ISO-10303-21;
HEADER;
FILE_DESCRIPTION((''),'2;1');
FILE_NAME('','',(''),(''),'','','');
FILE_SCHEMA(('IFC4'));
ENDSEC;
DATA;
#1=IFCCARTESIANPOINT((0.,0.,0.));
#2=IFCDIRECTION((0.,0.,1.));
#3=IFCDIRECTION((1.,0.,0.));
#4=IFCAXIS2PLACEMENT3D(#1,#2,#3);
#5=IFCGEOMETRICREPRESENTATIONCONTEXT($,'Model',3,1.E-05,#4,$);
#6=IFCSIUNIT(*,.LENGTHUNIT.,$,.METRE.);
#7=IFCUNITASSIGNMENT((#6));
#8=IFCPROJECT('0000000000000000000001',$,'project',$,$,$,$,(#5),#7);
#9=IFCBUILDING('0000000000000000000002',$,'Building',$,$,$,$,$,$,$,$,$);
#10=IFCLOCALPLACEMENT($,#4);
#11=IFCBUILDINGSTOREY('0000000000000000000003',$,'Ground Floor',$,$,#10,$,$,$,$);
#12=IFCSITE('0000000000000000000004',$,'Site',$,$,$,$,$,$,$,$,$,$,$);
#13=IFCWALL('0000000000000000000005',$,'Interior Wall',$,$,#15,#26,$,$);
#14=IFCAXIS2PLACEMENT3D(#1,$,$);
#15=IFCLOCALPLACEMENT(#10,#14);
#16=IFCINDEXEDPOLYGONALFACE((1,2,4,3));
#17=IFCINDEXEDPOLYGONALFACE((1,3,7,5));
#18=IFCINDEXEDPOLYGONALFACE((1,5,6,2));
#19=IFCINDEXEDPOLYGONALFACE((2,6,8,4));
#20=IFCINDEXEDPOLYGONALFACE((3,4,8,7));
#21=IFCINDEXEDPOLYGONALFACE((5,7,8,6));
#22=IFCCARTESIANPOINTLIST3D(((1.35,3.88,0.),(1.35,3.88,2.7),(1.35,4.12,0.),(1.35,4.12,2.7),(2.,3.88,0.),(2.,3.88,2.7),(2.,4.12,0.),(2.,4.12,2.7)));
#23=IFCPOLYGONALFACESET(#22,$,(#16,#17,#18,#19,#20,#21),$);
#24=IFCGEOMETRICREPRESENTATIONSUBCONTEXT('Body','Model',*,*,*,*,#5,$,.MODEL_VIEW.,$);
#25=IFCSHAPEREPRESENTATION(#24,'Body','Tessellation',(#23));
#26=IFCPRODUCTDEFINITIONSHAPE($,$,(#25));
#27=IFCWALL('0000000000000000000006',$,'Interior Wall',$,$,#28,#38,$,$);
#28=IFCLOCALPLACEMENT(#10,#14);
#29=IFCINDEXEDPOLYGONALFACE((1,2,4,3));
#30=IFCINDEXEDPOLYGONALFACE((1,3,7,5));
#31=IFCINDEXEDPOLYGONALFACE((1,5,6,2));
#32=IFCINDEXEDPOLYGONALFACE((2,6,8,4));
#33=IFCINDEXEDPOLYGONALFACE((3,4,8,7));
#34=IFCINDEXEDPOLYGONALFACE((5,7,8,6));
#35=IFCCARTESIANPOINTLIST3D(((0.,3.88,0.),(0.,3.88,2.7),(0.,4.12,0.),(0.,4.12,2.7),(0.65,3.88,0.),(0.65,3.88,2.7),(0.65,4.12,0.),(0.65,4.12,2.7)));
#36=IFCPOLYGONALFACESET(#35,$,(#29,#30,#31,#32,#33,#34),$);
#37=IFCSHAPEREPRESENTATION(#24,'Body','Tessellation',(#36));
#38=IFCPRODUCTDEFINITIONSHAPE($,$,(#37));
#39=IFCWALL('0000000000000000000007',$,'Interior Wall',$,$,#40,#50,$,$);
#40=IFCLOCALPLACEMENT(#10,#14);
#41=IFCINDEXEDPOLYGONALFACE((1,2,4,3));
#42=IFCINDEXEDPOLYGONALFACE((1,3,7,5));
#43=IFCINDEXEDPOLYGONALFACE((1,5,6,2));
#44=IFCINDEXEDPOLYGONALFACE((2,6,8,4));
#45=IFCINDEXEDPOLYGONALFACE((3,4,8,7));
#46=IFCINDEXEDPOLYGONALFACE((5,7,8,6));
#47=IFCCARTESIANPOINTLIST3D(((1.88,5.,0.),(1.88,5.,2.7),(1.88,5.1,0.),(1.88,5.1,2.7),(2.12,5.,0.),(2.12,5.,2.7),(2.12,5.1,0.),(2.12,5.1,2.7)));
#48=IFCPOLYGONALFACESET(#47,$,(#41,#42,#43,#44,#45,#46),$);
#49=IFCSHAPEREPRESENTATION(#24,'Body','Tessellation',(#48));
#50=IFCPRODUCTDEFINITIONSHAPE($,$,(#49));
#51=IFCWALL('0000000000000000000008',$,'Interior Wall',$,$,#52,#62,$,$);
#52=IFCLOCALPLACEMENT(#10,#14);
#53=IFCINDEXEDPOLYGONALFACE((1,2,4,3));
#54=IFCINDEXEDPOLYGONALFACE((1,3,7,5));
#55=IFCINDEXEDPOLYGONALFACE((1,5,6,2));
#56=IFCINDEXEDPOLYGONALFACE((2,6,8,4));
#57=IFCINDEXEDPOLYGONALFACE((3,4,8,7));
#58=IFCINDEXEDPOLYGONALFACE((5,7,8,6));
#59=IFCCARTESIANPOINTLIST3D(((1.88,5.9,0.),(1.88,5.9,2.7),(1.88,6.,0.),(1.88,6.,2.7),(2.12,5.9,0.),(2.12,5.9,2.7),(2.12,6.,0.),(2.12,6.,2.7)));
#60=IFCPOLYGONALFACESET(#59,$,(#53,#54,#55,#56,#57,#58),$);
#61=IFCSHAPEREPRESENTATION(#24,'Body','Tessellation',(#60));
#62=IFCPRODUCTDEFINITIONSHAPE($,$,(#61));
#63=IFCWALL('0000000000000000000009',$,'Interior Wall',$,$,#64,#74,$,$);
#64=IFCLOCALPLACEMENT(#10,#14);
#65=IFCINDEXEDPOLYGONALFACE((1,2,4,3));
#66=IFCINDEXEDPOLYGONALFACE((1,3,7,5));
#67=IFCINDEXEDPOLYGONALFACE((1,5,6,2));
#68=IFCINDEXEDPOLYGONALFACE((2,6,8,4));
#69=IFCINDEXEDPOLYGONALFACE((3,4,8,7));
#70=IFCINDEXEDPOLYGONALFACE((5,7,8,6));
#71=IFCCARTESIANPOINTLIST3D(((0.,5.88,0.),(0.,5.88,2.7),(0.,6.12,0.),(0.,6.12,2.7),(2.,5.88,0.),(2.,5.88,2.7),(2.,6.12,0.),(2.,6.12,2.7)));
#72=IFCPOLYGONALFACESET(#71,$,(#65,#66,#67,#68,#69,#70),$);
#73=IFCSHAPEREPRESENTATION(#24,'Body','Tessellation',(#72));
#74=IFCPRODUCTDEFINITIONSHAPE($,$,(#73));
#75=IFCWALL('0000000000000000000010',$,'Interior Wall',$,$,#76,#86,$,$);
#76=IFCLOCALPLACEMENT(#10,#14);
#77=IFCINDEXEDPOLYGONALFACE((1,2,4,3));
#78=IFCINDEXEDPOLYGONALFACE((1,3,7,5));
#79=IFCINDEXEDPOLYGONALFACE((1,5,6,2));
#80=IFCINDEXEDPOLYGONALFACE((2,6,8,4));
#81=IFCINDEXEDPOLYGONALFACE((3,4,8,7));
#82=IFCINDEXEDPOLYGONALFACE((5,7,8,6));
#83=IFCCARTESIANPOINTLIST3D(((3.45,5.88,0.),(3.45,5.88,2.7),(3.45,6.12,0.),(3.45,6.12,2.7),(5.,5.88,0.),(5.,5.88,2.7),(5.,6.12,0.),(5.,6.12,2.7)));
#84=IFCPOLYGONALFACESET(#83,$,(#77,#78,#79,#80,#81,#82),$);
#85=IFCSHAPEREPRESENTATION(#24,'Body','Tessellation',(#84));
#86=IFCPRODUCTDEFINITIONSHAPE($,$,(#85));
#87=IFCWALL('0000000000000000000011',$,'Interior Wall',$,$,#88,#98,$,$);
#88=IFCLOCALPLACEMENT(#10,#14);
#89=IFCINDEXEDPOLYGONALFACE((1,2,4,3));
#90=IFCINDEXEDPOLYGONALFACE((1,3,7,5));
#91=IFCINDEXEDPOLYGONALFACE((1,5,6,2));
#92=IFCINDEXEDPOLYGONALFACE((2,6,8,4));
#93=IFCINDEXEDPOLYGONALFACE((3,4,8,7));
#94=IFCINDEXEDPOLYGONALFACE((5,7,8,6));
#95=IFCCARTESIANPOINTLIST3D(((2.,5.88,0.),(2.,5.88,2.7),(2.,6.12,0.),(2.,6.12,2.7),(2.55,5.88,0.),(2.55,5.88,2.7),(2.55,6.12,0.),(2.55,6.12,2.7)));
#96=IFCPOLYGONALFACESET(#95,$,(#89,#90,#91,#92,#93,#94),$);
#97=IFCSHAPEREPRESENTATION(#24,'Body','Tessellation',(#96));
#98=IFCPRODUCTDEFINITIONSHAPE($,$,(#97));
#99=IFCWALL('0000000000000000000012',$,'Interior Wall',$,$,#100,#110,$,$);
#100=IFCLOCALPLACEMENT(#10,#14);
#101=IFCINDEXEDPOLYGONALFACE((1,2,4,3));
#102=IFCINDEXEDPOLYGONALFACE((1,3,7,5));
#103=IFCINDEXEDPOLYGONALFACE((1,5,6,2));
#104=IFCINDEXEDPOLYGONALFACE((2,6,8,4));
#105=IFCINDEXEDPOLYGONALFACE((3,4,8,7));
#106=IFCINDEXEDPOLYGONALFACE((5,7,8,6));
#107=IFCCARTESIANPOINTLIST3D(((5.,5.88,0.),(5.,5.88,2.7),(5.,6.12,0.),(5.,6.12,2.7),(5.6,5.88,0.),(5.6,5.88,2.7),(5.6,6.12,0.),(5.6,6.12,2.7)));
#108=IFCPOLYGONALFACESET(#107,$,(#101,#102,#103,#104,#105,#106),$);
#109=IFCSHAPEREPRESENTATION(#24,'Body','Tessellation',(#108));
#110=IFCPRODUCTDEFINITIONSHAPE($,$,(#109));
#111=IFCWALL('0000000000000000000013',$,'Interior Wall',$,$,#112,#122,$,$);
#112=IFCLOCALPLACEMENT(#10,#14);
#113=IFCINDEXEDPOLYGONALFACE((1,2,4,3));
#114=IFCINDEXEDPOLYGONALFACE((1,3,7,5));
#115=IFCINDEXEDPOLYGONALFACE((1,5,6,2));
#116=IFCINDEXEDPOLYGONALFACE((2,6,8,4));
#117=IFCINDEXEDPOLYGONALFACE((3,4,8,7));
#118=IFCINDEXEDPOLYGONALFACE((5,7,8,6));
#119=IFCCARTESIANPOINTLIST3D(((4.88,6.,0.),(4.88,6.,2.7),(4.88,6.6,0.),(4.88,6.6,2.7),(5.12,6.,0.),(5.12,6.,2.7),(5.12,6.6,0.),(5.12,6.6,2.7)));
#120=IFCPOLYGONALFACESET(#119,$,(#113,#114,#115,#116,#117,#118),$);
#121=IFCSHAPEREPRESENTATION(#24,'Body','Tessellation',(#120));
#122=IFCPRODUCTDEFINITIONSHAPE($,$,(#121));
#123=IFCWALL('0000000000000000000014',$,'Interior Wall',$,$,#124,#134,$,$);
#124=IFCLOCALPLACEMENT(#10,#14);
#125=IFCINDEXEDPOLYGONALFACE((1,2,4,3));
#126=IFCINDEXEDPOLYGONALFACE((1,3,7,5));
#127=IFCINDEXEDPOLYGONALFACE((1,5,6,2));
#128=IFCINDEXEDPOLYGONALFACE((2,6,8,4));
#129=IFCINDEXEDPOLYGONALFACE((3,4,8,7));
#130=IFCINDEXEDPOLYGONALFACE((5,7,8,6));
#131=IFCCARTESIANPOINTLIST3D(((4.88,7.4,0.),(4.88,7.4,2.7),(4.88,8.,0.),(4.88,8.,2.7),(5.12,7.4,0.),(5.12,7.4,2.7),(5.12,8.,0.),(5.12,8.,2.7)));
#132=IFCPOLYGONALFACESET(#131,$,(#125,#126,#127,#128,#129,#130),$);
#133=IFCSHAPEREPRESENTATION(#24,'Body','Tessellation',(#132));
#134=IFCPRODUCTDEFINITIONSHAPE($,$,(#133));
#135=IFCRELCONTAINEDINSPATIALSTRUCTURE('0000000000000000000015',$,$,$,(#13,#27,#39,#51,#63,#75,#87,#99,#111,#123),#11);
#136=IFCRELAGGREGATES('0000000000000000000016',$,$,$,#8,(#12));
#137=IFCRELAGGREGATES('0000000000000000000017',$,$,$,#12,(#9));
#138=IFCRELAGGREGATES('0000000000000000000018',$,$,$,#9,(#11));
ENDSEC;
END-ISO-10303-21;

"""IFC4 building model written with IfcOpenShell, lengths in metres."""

from ifc_helpers import new_model, si_unit, frame, origin_with_axes, place, context, subcontext, project, spatial, indexed_curve, outline, extrude, element, save


model = new_model("IFC4")

# Units and contexts
model_context = context("Model", 3, precision=1e-05, world=origin_with_axes())
body_context = subcontext(model_context, "Body", "Model", "MODEL_VIEW")
ifc_project = project(units=[si_unit("LENGTHUNIT", "METRE")], contexts=[model_context])

# Site, building, storey
site = spatial("IfcSite", under=ifc_project, Name="Site")
building = spatial("IfcBuilding", under=site, Name="Building")
storey_placement = place(None, origin_with_axes())
storey = spatial("IfcBuildingStorey", under=building, at=storey_placement, Name="Ground Floor")

# Walls
for number, where, z_axis, x_axis, name in (
    (1, (2.0, 4.0, 0.0), (0.0, 0.0, 1.0), (-1.0, 0.0, 0.0), "Interior Wall"),
    (2, (0.65, 4.0, 0.0), (0.0, 0.0, 1.0), (-1.0, 0.0, 0.0), "Interior Wall"),
):
    element("IfcWall", number, at=place(storey_placement, frame(where, z_axis=z_axis, x_axis=x_axis)), inside=storey, Name=name, context=body_context, shape_type="SweptSolid", body=[
        extrude(outline(indexed_curve([(0.0, 0.0), (0.0, 0.24), (0.65, 0.24), (0.65, 0.0), (0.0, 0.0)], self_intersect=False)), frame((0.0, -0.12, 0.0), z_axis=(0.0, 0.0, 1.0), x_axis=(1.0, 0.0, 0.0)), (0.0, 0.0, 1.0), 2.7),
    ])
for number, where, z_axis, x_axis, name in (
    (3, (2.0, 5.0, 0.0), (0.0, 0.0, 1.0), (0.0, 1.0, 0.0), "Interior Wall"),
    (4, (2.0, 5.9, 0.0), (0.0, 0.0, 1.0), (0.0, 1.0, 0.0), "Interior Wall"),
):
    element("IfcWall", number, at=place(storey_placement, frame(where, z_axis=z_axis, x_axis=x_axis)), inside=storey, Name=name, context=body_context, shape_type="SweptSolid", body=[
        extrude(outline(indexed_curve([(0.0, 0.0), (0.0, 0.24), (0.1, 0.24), (0.1, 0.0), (0.0, 0.0)], self_intersect=False)), frame((0.0, -0.12, 0.0), z_axis=(0.0, 0.0, 1.0), x_axis=(1.0, 0.0, 0.0)), (0.0, 0.0, 1.0), 2.7),
    ])
wall_1_placement = place(storey_placement, frame((2.0, 6.0, 0.0), z_axis=(0.0, 0.0, 1.0), x_axis=(-1.0, 0.0, 0.0)))
element("IfcWall", 5, at=wall_1_placement, inside=storey, Name="Interior Wall", context=body_context, shape_type="SweptSolid", body=[
    extrude(outline(indexed_curve([(0.0, 0.0), (0.0, 0.24), (2.0, 0.24), (2.0, 0.0), (0.0, 0.0)], self_intersect=False)), frame((0.0, -0.12, 0.0), z_axis=(0.0, 0.0, 1.0), x_axis=(1.0, 0.0, 0.0)), (0.0, 0.0, 1.0), 2.7),
])
wall_2_placement = place(storey_placement, frame((5.0, 6.0, 0.0), z_axis=(0.0, 0.0, 1.0), x_axis=(-1.0, 0.0, 0.0)))
element("IfcWall", 6, at=wall_2_placement, inside=storey, Name="Interior Wall", context=body_context, shape_type="SweptSolid", body=[
    extrude(outline(indexed_curve([(0.0, 0.0), (0.0, 0.24), (1.55, 0.24), (1.55, 0.0), (0.0, 0.0)], self_intersect=False)), frame((0.0, -0.12, 0.0), z_axis=(0.0, 0.0, 1.0), x_axis=(1.0, 0.0, 0.0)), (0.0, 0.0, 1.0), 2.7),
])
wall_3_placement = place(storey_placement, frame((2.55, 6.0, 0.0), z_axis=(0.0, 0.0, 1.0), x_axis=(-1.0, 0.0, 0.0)))
element("IfcWall", 7, at=wall_3_placement, inside=storey, Name="Interior Wall", context=body_context, shape_type="SweptSolid", body=[
    extrude(outline(indexed_curve([(0.0, 0.0), (0.0, 0.24), (0.55, 0.24), (0.55, 0.0), (0.0, 0.0)], self_intersect=False)), frame((0.0, -0.12, 0.0), z_axis=(0.0, 0.0, 1.0), x_axis=(1.0, 0.0, 0.0)), (0.0, 0.0, 1.0), 2.7),
])
for number, where, z_axis, x_axis, name in (
    (8, (5.6, 6.0, 0.0), (0.0, 0.0, 1.0), (-1.0, 0.0, 0.0), "Interior Wall"),
    (9, (5.0, 6.0, 0.0), (0.0, 0.0, 1.0), (0.0, 1.0, 0.0), "Interior Wall"),
    (10, (5.0, 7.4, 0.0), (0.0, 0.0, 1.0), (0.0, 1.0, 0.0), "Interior Wall"),
):
    element("IfcWall", number, at=place(storey_placement, frame(where, z_axis=z_axis, x_axis=x_axis)), inside=storey, Name=name, context=body_context, shape_type="SweptSolid", body=[
        extrude(outline(indexed_curve([(0.0, 0.0), (0.0, 0.24), (0.6, 0.24), (0.6, 0.0), (0.0, 0.0)], self_intersect=False)), frame((0.0, -0.12, 0.0), z_axis=(0.0, 0.0, 1.0), x_axis=(1.0, 0.0, 0.0)), (0.0, 0.0, 1.0), 2.7),
    ])

save(model, "model.ifc")
